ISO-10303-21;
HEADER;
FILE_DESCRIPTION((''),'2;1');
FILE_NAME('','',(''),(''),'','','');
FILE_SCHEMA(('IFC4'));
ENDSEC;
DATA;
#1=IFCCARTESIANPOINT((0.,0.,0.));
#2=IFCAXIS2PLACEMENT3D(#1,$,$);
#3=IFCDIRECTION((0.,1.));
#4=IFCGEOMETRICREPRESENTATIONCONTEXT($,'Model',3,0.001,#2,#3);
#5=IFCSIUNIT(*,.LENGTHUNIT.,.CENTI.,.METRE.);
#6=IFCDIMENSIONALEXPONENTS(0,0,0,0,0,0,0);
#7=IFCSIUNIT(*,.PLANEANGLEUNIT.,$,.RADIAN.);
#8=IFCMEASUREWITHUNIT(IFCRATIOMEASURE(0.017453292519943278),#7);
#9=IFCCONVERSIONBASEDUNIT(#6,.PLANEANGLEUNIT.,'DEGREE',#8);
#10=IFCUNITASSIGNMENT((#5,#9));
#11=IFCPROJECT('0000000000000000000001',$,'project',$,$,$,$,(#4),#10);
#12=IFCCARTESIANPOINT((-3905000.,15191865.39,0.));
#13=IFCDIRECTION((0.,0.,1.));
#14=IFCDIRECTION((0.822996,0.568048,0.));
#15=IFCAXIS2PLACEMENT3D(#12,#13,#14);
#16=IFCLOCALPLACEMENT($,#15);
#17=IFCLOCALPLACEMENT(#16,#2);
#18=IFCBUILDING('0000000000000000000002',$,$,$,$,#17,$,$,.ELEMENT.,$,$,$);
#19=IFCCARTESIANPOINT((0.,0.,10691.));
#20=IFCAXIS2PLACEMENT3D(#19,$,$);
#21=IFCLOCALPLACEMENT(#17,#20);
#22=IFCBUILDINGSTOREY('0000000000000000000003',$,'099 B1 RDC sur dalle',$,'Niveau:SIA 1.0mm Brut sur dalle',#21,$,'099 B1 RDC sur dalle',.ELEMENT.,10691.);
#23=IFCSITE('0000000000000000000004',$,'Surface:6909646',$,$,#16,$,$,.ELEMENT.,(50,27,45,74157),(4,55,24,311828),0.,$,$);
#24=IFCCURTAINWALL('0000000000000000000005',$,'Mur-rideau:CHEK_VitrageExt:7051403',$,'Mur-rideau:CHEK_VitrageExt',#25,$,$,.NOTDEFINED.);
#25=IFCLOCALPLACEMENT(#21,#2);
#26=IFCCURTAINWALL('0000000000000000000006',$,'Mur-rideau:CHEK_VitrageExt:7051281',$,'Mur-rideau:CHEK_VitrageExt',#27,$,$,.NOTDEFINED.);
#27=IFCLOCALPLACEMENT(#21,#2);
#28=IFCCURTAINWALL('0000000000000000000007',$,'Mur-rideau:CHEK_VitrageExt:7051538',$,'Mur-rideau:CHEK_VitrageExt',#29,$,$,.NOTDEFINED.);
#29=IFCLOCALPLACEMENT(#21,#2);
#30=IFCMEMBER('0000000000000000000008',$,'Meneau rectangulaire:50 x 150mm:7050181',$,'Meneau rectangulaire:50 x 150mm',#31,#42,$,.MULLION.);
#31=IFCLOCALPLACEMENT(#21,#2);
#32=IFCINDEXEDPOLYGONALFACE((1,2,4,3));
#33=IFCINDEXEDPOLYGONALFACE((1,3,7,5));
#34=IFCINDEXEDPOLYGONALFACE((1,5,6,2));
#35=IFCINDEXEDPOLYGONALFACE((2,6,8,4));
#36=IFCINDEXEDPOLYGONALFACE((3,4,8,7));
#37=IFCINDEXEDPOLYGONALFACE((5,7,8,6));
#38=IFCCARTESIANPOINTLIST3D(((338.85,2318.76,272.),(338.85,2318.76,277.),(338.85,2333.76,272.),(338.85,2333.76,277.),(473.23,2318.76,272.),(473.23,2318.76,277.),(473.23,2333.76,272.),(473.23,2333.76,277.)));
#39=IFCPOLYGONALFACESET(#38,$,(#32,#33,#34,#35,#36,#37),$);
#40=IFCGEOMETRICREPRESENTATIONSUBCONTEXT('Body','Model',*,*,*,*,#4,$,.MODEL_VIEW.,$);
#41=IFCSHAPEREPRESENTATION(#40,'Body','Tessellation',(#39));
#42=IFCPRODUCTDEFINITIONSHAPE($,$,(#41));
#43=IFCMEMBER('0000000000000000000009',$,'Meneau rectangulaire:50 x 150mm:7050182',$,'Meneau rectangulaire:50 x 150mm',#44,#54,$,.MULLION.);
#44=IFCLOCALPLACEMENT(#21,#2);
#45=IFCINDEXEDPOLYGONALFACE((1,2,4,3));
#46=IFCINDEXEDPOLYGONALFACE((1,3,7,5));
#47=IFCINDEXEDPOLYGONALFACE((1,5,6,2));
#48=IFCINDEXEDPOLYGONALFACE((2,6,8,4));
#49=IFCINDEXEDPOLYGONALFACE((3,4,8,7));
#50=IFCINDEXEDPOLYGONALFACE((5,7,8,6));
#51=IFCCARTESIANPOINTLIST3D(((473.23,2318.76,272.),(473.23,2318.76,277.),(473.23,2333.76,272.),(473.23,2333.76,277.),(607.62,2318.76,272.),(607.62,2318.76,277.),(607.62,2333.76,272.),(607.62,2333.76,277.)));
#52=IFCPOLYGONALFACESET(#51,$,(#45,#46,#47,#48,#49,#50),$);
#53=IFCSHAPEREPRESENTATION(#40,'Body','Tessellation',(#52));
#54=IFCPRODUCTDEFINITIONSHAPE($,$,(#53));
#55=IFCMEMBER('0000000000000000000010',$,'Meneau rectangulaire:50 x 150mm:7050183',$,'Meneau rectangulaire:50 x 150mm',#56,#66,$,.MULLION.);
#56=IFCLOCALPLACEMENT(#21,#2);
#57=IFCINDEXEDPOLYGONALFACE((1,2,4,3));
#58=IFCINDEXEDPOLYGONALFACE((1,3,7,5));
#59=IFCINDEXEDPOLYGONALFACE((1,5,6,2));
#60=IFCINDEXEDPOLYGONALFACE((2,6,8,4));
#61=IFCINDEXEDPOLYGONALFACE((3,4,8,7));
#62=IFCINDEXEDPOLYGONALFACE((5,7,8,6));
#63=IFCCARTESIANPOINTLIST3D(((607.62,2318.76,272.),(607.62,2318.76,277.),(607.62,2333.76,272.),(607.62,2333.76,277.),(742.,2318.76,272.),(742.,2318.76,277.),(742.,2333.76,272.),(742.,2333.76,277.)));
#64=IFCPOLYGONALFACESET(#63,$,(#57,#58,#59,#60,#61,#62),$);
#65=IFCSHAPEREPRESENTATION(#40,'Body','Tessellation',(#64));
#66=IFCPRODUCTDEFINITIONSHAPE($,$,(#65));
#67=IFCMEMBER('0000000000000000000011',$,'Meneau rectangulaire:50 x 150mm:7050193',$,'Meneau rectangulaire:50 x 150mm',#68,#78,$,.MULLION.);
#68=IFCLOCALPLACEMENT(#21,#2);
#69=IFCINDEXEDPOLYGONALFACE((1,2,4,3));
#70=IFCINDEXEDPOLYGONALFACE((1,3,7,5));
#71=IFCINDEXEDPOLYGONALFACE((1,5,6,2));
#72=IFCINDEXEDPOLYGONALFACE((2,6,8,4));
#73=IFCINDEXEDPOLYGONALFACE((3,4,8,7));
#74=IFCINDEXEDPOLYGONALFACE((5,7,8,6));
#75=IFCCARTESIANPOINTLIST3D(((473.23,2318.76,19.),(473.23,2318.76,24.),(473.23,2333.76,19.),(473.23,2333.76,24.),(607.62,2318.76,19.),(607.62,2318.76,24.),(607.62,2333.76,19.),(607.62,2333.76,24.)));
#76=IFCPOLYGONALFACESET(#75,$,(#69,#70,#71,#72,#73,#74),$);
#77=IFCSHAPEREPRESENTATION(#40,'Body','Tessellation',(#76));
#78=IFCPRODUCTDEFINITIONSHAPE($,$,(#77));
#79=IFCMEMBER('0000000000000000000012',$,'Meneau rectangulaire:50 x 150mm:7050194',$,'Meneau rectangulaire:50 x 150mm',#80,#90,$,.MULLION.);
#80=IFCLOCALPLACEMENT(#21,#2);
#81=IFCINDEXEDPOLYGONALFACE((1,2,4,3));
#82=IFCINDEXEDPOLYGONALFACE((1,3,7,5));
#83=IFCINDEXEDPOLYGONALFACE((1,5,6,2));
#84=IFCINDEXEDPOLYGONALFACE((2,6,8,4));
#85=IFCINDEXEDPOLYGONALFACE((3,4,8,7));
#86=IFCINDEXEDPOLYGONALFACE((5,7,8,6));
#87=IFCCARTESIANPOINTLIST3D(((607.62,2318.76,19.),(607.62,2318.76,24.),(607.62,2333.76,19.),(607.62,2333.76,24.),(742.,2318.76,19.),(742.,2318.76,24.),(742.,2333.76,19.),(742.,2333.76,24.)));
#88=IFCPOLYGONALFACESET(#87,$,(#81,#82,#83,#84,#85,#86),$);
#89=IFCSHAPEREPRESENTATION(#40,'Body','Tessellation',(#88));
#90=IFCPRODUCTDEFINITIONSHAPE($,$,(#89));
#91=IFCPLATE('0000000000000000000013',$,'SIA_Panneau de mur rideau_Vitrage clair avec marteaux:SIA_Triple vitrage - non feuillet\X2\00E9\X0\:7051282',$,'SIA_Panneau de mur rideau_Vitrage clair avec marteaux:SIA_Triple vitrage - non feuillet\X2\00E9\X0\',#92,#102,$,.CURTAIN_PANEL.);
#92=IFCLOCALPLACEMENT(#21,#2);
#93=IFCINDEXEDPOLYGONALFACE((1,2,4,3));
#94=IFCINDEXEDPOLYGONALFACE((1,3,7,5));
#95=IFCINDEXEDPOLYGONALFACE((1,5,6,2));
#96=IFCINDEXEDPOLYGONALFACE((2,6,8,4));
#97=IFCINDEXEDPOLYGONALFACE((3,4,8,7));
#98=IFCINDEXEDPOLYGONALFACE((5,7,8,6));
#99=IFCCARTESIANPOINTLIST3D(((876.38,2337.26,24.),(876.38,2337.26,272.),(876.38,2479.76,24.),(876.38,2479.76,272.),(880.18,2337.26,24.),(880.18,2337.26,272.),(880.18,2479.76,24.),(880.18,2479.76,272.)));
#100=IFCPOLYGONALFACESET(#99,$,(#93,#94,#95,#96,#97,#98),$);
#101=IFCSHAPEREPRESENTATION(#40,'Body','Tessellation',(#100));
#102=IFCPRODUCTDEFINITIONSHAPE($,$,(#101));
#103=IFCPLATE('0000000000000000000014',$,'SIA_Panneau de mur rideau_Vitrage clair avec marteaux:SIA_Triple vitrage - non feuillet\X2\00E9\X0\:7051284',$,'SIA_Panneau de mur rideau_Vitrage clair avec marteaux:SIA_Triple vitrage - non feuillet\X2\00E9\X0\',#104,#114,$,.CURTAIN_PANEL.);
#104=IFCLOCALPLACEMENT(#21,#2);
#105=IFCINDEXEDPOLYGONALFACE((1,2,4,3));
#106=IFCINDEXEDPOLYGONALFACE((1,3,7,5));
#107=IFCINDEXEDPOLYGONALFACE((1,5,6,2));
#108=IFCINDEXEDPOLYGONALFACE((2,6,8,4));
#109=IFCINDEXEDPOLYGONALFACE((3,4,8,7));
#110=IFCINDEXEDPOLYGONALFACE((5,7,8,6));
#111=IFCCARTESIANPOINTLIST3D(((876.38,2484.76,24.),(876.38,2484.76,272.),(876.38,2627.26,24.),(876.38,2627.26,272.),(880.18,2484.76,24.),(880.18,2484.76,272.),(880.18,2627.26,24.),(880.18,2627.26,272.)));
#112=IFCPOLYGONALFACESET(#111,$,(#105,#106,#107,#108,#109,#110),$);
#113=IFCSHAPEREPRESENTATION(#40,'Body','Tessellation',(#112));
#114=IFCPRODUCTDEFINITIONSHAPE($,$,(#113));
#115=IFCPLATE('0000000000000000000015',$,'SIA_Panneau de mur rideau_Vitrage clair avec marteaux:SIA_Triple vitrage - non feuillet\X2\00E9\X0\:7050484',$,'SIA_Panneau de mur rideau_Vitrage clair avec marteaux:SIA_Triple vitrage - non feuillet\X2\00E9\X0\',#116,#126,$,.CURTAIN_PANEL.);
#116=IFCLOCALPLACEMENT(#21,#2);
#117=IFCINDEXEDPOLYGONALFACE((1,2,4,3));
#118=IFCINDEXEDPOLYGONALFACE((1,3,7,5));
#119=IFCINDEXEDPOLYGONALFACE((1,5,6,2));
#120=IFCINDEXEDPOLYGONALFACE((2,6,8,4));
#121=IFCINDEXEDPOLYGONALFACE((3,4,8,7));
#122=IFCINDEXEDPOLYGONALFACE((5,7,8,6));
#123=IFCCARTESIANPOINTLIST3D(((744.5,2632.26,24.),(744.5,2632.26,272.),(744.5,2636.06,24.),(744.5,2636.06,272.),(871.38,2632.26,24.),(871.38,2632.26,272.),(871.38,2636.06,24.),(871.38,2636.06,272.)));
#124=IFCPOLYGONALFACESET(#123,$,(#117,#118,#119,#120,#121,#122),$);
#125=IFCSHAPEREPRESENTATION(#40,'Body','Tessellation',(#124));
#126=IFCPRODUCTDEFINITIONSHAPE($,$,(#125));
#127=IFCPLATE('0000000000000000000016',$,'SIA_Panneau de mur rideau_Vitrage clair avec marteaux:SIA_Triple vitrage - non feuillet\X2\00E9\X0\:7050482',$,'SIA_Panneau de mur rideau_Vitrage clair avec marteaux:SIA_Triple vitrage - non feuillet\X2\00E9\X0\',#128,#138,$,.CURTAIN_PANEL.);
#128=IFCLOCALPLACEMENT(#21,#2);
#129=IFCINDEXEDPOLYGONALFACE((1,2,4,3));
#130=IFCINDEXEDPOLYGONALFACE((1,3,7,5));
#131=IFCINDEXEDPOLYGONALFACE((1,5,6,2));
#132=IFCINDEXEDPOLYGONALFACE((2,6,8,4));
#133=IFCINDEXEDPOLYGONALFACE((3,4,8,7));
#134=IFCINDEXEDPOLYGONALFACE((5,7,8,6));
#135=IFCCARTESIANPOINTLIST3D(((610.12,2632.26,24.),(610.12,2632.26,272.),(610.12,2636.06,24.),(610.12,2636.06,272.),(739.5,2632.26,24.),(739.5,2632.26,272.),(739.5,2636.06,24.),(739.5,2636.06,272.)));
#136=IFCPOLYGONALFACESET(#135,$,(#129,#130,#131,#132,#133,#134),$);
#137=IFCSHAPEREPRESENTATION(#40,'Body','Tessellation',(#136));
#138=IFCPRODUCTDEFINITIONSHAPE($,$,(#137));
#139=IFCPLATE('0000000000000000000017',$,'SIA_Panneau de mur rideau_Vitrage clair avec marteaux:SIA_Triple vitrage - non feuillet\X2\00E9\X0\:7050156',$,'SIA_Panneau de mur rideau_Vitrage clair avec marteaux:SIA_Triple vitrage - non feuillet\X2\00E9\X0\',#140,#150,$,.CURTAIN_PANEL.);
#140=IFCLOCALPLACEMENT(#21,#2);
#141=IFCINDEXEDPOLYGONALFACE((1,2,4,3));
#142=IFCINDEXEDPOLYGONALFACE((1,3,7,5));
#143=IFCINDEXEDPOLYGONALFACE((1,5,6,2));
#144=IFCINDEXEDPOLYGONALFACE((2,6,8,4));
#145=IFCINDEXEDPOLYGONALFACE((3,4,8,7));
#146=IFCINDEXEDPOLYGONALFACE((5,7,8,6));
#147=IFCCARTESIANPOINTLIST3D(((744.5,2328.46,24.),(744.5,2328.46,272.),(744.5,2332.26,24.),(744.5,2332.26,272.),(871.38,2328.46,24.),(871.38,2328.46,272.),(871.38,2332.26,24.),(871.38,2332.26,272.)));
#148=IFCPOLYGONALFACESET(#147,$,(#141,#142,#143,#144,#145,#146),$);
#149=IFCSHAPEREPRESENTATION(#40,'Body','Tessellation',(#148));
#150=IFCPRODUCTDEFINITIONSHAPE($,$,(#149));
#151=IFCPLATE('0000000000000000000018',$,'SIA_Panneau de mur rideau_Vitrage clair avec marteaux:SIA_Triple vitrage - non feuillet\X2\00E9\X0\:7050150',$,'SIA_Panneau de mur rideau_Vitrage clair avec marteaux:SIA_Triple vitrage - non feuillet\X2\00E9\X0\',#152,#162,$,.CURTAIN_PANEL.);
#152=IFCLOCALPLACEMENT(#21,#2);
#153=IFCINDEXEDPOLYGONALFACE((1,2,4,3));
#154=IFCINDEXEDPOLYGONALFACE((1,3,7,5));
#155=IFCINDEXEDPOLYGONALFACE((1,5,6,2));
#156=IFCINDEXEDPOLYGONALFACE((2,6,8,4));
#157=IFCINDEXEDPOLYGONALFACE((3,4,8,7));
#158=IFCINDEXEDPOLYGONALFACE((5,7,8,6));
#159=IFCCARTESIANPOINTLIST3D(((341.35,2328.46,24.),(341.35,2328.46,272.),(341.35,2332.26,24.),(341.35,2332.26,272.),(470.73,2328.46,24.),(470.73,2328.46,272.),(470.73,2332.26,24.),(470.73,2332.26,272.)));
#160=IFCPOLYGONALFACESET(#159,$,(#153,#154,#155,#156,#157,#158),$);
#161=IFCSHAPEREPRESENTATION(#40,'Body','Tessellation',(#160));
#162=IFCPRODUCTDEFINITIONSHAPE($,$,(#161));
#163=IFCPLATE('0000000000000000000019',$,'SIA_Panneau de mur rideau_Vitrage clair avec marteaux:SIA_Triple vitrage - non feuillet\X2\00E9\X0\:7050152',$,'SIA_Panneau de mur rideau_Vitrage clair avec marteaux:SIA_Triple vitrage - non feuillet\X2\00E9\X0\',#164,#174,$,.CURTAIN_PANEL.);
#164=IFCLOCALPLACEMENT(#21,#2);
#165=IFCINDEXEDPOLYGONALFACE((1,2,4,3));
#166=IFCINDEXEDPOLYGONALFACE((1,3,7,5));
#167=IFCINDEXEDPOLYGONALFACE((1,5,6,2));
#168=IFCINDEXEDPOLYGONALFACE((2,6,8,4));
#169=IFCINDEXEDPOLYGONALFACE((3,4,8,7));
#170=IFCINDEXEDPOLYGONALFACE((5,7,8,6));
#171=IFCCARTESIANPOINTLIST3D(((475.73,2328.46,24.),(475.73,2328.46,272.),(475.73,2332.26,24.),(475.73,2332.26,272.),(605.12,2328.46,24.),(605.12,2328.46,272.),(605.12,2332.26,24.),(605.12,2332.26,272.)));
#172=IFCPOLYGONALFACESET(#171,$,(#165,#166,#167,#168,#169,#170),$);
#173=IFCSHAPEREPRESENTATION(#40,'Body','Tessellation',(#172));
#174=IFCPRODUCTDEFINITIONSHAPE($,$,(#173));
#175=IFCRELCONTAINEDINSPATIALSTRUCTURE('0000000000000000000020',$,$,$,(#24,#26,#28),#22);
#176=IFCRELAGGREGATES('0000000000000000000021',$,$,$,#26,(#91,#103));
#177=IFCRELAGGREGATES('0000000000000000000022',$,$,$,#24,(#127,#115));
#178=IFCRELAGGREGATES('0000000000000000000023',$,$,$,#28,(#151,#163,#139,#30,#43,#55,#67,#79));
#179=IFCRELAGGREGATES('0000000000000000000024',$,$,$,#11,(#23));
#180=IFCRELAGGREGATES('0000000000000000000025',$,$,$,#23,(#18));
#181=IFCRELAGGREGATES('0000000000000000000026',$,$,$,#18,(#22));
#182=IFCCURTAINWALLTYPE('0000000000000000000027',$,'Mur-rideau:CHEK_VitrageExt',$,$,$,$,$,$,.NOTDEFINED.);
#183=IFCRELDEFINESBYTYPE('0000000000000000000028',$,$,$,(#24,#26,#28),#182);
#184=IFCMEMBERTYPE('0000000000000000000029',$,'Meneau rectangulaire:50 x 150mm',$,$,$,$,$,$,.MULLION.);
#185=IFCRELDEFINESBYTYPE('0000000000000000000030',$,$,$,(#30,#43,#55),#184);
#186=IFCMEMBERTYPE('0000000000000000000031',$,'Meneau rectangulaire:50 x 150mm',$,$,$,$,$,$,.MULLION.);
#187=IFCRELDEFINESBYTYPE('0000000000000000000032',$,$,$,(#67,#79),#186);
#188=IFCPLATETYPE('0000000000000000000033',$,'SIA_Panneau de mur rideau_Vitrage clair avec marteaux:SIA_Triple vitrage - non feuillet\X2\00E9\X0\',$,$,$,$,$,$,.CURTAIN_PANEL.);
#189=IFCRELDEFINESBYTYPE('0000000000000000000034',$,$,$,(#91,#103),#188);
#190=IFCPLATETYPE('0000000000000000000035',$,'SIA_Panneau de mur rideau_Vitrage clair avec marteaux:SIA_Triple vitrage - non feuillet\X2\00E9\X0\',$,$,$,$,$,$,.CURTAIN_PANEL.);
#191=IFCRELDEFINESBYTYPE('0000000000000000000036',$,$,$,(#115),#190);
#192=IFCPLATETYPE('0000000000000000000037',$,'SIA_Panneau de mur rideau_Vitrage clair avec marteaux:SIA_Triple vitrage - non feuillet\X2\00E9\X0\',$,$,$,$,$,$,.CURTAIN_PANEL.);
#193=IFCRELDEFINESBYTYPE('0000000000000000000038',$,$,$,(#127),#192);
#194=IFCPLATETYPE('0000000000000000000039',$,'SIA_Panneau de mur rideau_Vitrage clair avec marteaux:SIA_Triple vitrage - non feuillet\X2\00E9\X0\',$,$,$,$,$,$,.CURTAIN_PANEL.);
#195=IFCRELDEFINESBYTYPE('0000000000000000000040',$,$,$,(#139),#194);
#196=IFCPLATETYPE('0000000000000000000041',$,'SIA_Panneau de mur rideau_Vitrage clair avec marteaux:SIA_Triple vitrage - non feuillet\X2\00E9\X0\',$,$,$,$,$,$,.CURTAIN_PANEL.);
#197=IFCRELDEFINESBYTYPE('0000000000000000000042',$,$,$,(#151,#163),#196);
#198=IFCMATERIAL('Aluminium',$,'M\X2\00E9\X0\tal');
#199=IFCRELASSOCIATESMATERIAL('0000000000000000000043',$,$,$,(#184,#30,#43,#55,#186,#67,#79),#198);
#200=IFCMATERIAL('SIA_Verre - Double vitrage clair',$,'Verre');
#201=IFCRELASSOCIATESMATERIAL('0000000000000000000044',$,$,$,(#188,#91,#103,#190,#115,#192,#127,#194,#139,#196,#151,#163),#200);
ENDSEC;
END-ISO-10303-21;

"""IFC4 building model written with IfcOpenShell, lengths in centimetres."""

from ifc_helpers import new_model, entity, si_unit, converted_unit, direction, frame, origin, place, context, subcontext, project, spatial, indexed_curve, outline, extrude, source, transform, mapped, material, type_object, type_shapes, element, aggregate, save


model = new_model("IFC4")

# Units and contexts
model_context = context("Model", 3, precision=0.001, world=origin(), true_north=direction((0.0, 1.0)))
body_context = subcontext(model_context, "Body", "Model", "MODEL_VIEW")
ifc_project = project(units=[si_unit("LENGTHUNIT", "METRE", prefix="CENTI"), converted_unit("PLANEANGLEUNIT", "DEGREE", entity("IfcRatioMeasure", 0.017453292519943278), si_unit("PLANEANGLEUNIT", "RADIAN"), dimensions=[0, 0, 0, 0, 0, 0, 0])], contexts=[model_context])

# Site, building, storey
site_placement = place(None, frame((-3905000.0, 15191865.39, 0.0), z_axis=(0.0, 0.0, 1.0), x_axis=(0.822996, 0.568048, 0.0)))
site = spatial("IfcSite", under=ifc_project, at=site_placement, Name="Surface:6909646", CompositionType="ELEMENT", RefLatitude=(50, 27, 45, 74157), RefLongitude=(4, 55, 24, 311828), RefElevation=0.0)
building_placement = place(site_placement, origin())
building = spatial("IfcBuilding", under=site, at=building_placement, CompositionType="ELEMENT")
storey_placement = place(building_placement, frame((0.0, 0.0, 10691.0)))
storey = spatial("IfcBuildingStorey", under=building, at=storey_placement, Name="099 B1 RDC sur dalle", ObjectType="Niveau:SIA 1.0mm Brut sur dalle", LongName="099 B1 RDC sur dalle", CompositionType="ELEMENT", Elevation=10691.0)

# Curtain wall
curtain_wall_type = type_object("IfcCurtainWallType", Name="Mur-rideau:CHEK_VitrageExt", PredefinedType="NOTDEFINED")
curtain_wall_1_placement = place(storey_placement, frame((0.0, 0.0, -10691.0)))
curtain_wall_1 = element("IfcCurtainWall", 1, at=curtain_wall_1_placement, inside=storey, type_object=curtain_wall_type, Name="Mur-rideau:CHEK_VitrageExt:7051403", ObjectType="Mur-rideau:CHEK_VitrageExt", PredefinedType="NOTDEFINED")
ifc_material_1 = material(Name="Aluminium", Category="Métal")

# Curtain wall
curtain_wall_2_placement = place(storey_placement, frame((0.0, 0.0, -10691.0)))
curtain_wall_2 = element("IfcCurtainWall", 2, at=curtain_wall_2_placement, inside=storey, type_object=curtain_wall_type, Name="Mur-rideau:CHEK_VitrageExt:7051281", ObjectType="Mur-rideau:CHEK_VitrageExt", PredefinedType="NOTDEFINED")

# Curtain wall
curtain_wall_3_placement = place(storey_placement, frame((0.0, 0.0, -10691.0)))
curtain_wall_3 = element("IfcCurtainWall", 3, at=curtain_wall_3_placement, inside=storey, type_object=curtain_wall_type, Name="Mur-rideau:CHEK_VitrageExt:7051538", ObjectType="Mur-rideau:CHEK_VitrageExt", PredefinedType="NOTDEFINED")

# Members
member_type_1 = type_object("IfcMemberType", Name="Meneau rectangulaire:50 x 150mm", PredefinedType="MULLION", material=ifc_material_1)
shared_shape_1 = source(origin(), body_context, "Body", "SweptSolid", [
    extrude(outline(indexed_curve([(-7.5, -2.5), (7.5, -2.5), (7.5, 2.5), (-7.5, 2.5), (-7.5, -2.5)], self_intersect=False)), frame((-2.5, 6.0, -134.38), z_axis=(0.0, 0.0, 1.0), x_axis=(0.0, -1.0, 0.0)), (0.0, 0.0, 1.0), 134.38),
])
type_shapes(member_type_1, [shared_shape_1])
member_1_placement = place(curtain_wall_3_placement, frame((473.23, 2332.26, 10968.0), z_axis=(1.0, 0.0, 0.0), x_axis=(0.0, 0.0, 1.0)))
member_1 = element("IfcMember", 4, at=member_1_placement, type_object=member_type_1, material=ifc_material_1, Name="Meneau rectangulaire:50 x 150mm:7050181", ObjectType="Meneau rectangulaire:50 x 150mm", PredefinedType="MULLION", context=body_context, shape_type="MappedRepresentation", body=[
    mapped(shared_shape_1, transform((0.0, 0.0, 0.0), scale=1.0)),
])
member_2_placement = place(curtain_wall_3_placement, frame((607.62, 2332.26, 10968.0), z_axis=(1.0, 0.0, 0.0), x_axis=(0.0, 0.0, 1.0)))
member_2 = element("IfcMember", 5, at=member_2_placement, type_object=member_type_1, material=ifc_material_1, Name="Meneau rectangulaire:50 x 150mm:7050182", ObjectType="Meneau rectangulaire:50 x 150mm", PredefinedType="MULLION", context=body_context, shape_type="MappedRepresentation", body=[
    mapped(shared_shape_1, transform((0.0, 0.0, 0.0), scale=1.0)),
])
member_3_placement = place(curtain_wall_3_placement, frame((742.0, 2332.26, 10968.0), z_axis=(1.0, 0.0, 0.0), x_axis=(0.0, 0.0, 1.0)))
member_3 = element("IfcMember", 6, at=member_3_placement, type_object=member_type_1, material=ifc_material_1, Name="Meneau rectangulaire:50 x 150mm:7050183", ObjectType="Meneau rectangulaire:50 x 150mm", PredefinedType="MULLION", context=body_context, shape_type="MappedRepresentation", body=[
    mapped(shared_shape_1, transform((0.0, 0.0, 0.0), scale=1.0)),
])
member_type_2 = type_object("IfcMemberType", Name="Meneau rectangulaire:50 x 150mm", PredefinedType="MULLION", material=ifc_material_1)
shared_shape_2 = source(origin(), body_context, "Body", "SweptSolid", [
    extrude(outline(indexed_curve([(-7.5, -2.5), (7.5, -2.5), (7.5, 2.5), (-7.5, 2.5), (-7.5, -2.5)], self_intersect=False)), frame((-2.5, 6.0, -134.38), z_axis=(0.0, 0.0, 1.0), x_axis=(0.0, -1.0, 0.0)), (0.0, 0.0, 1.0), 134.38),
])
type_shapes(member_type_2, [shared_shape_2])
member_4_placement = place(curtain_wall_3_placement, frame((473.23, 2332.26, 10710.0), z_axis=(-1.0, 0.0, 0.0), x_axis=(0.0, 0.0, -1.0)))
member_4 = element("IfcMember", 7, at=member_4_placement, type_object=member_type_2, material=ifc_material_1, Name="Meneau rectangulaire:50 x 150mm:7050193", ObjectType="Meneau rectangulaire:50 x 150mm", PredefinedType="MULLION", context=body_context, shape_type="MappedRepresentation", body=[
    mapped(shared_shape_2, transform((0.0, 0.0, 0.0), scale=1.0)),
])
member_5_placement = place(curtain_wall_3_placement, frame((607.62, 2332.26, 10710.0), z_axis=(-1.0, 0.0, 0.0), x_axis=(0.0, 0.0, -1.0)))
member_5 = element("IfcMember", 8, at=member_5_placement, type_object=member_type_2, material=ifc_material_1, Name="Meneau rectangulaire:50 x 150mm:7050194", ObjectType="Meneau rectangulaire:50 x 150mm", PredefinedType="MULLION", context=body_context, shape_type="MappedRepresentation", body=[
    mapped(shared_shape_2, transform((0.0, 0.0, 0.0), scale=1.0)),
])

# Plates
ifc_material_2 = material(Name="SIA_Verre - Double vitrage clair", Category="Verre")
plate_type_1 = type_object("IfcPlateType", Name="SIA_Panneau de mur rideau_Vitrage clair avec marteaux:SIA_Triple vitrage - non feuilleté", PredefinedType="CURTAIN_PANEL", material=ifc_material_2)
shared_shape_3 = source(origin(), body_context, "Body", "SweptSolid", [
    extrude(outline(indexed_curve([(-1.9, -71.25), (1.9, -71.25), (1.9, 71.25), (-1.9, 71.25), (-1.9, -71.25)], self_intersect=False)), frame((0.0, -1.9, 0.0), z_axis=(0.0, 0.0, 1.0), x_axis=(0.0, 1.0, 0.0)), (0.0, 0.0, 1.0), 248.0),
])
type_shapes(plate_type_1, [shared_shape_3])
plate_1_placement = place(curtain_wall_2_placement, frame((876.38, 2408.51, 10715.0), z_axis=(0.0, 0.0, 1.0), x_axis=(0.0, 1.0, 0.0)))
plate_1 = element("IfcPlate", 9, at=plate_1_placement, type_object=plate_type_1, material=ifc_material_2, Name="SIA_Panneau de mur rideau_Vitrage clair avec marteaux:SIA_Triple vitrage - non feuilleté:7051282", ObjectType="SIA_Panneau de mur rideau_Vitrage clair avec marteaux:SIA_Triple vitrage - non feuilleté", PredefinedType="CURTAIN_PANEL", context=body_context, shape_type="MappedRepresentation", body=[
    mapped(shared_shape_3, transform((0.0, 0.0, 0.0), scale=1.0)),
])
plate_2_placement = place(curtain_wall_2_placement, frame((876.38, 2556.01, 10715.0), z_axis=(0.0, 0.0, 1.0), x_axis=(0.0, 1.0, 0.0)))
plate_2 = element("IfcPlate", 10, at=plate_2_placement, type_object=plate_type_1, material=ifc_material_2, Name="SIA_Panneau de mur rideau_Vitrage clair avec marteaux:SIA_Triple vitrage - non feuilleté:7051284", ObjectType="SIA_Panneau de mur rideau_Vitrage clair avec marteaux:SIA_Triple vitrage - non feuilleté", PredefinedType="CURTAIN_PANEL", context=body_context, shape_type="MappedRepresentation", body=[
    mapped(shared_shape_3, transform((0.0, 0.0, 0.0), scale=1.0)),
])
aggregate(curtain_wall_2, [plate_1, plate_2])
plate_type_2 = type_object("IfcPlateType", Name="SIA_Panneau de mur rideau_Vitrage clair avec marteaux:SIA_Triple vitrage - non feuilleté", PredefinedType="CURTAIN_PANEL", material=ifc_material_2)
shared_shape_4 = source(origin(), body_context, "Body", "SweptSolid", [
    extrude(outline(indexed_curve([(-63.44, -1.9), (63.44, -1.9), (63.44, 1.9), (-63.44, 1.9), (-63.44, -1.9)], self_intersect=False)), frame((0.0, 1.9, 0.0), z_axis=(0.0, 0.0, 1.0), x_axis=(-1.0, 0.0, 0.0)), (0.0, 0.0, 1.0), 248.0),
])
type_shapes(plate_type_2, [shared_shape_4])
plate_3_placement = place(curtain_wall_1_placement, frame((807.94, 2632.26, 10715.0)))
plate_3 = element("IfcPlate", 11, at=plate_3_placement, type_object=plate_type_2, material=ifc_material_2, Name="SIA_Panneau de mur rideau_Vitrage clair avec marteaux:SIA_Triple vitrage - non feuilleté:7050484", ObjectType="SIA_Panneau de mur rideau_Vitrage clair avec marteaux:SIA_Triple vitrage - non feuilleté", PredefinedType="CURTAIN_PANEL", context=body_context, shape_type="MappedRepresentation", body=[
    mapped(shared_shape_4, transform((0.0, 0.0, 0.0), scale=1.0)),
])
plate_type_3 = type_object("IfcPlateType", Name="SIA_Panneau de mur rideau_Vitrage clair avec marteaux:SIA_Triple vitrage - non feuilleté", PredefinedType="CURTAIN_PANEL", material=ifc_material_2)
shared_shape_5 = source(origin(), body_context, "Body", "SweptSolid", [
    extrude(outline(indexed_curve([(-64.69, -1.9), (64.69, -1.9), (64.69, 1.9), (-64.69, 1.9), (-64.69, -1.9)], self_intersect=False)), frame((0.0, 1.9, 0.0), z_axis=(0.0, 0.0, 1.0), x_axis=(-1.0, 0.0, 0.0)), (0.0, 0.0, 1.0), 248.0),
])
type_shapes(plate_type_3, [shared_shape_5])
plate_4_placement = place(curtain_wall_1_placement, frame((674.81, 2632.26, 10715.0)))
plate_4 = element("IfcPlate", 12, at=plate_4_placement, type_object=plate_type_3, material=ifc_material_2, Name="SIA_Panneau de mur rideau_Vitrage clair avec marteaux:SIA_Triple vitrage - non feuilleté:7050482", ObjectType="SIA_Panneau de mur rideau_Vitrage clair avec marteaux:SIA_Triple vitrage - non feuilleté", PredefinedType="CURTAIN_PANEL", context=body_context, shape_type="MappedRepresentation", body=[
    mapped(shared_shape_5, transform((0.0, 0.0, 0.0), scale=1.0)),
])
aggregate(curtain_wall_1, [plate_4, plate_3])
plate_type_4 = type_object("IfcPlateType", Name="SIA_Panneau de mur rideau_Vitrage clair avec marteaux:SIA_Triple vitrage - non feuilleté", PredefinedType="CURTAIN_PANEL", material=ifc_material_2)
shared_shape_6 = source(origin(), body_context, "Body", "SweptSolid", [
    extrude(outline(indexed_curve([(-1.9, -63.44), (1.9, -63.44), (1.9, 63.44), (-1.9, 63.44), (-1.9, -63.44)], self_intersect=False)), frame((0.0, -1.9, 0.0), z_axis=(0.0, 0.0, 1.0), x_axis=(0.0, 1.0, 0.0)), (0.0, 0.0, 1.0), 248.0),
])
type_shapes(plate_type_4, [shared_shape_6])
plate_5_placement = place(curtain_wall_3_placement, frame((807.94, 2332.26, 10715.0)))
plate_5 = element("IfcPlate", 13, at=plate_5_placement, type_object=plate_type_4, material=ifc_material_2, Name="SIA_Panneau de mur rideau_Vitrage clair avec marteaux:SIA_Triple vitrage - non feuilleté:7050156", ObjectType="SIA_Panneau de mur rideau_Vitrage clair avec marteaux:SIA_Triple vitrage - non feuilleté", PredefinedType="CURTAIN_PANEL", context=body_context, shape_type="MappedRepresentation", body=[
    mapped(shared_shape_6, transform((0.0, 0.0, 0.0), scale=1.0)),
])
plate_type_5 = type_object("IfcPlateType", Name="SIA_Panneau de mur rideau_Vitrage clair avec marteaux:SIA_Triple vitrage - non feuilleté", PredefinedType="CURTAIN_PANEL", material=ifc_material_2)
shared_shape_7 = source(origin(), body_context, "Body", "SweptSolid", [
    extrude(outline(indexed_curve([(-1.9, -64.69), (1.9, -64.69), (1.9, 64.69), (-1.9, 64.69), (-1.9, -64.69)], self_intersect=False)), frame((0.0, -1.9, 0.0), z_axis=(0.0, 0.0, 1.0), x_axis=(0.0, 1.0, 0.0)), (0.0, 0.0, 1.0), 248.0),
])
type_shapes(plate_type_5, [shared_shape_7])
plate_6_placement = place(curtain_wall_3_placement, frame((406.04, 2332.26, 10715.0)))
plate_6 = element("IfcPlate", 14, at=plate_6_placement, type_object=plate_type_5, material=ifc_material_2, Name="SIA_Panneau de mur rideau_Vitrage clair avec marteaux:SIA_Triple vitrage - non feuilleté:7050150", ObjectType="SIA_Panneau de mur rideau_Vitrage clair avec marteaux:SIA_Triple vitrage - non feuilleté", PredefinedType="CURTAIN_PANEL", context=body_context, shape_type="MappedRepresentation", body=[
    mapped(shared_shape_7, transform((0.0, 0.0, 0.0), scale=1.0)),
])
plate_7_placement = place(curtain_wall_3_placement, frame((540.43, 2332.26, 10715.0)))
plate_7 = element("IfcPlate", 15, at=plate_7_placement, type_object=plate_type_5, material=ifc_material_2, Name="SIA_Panneau de mur rideau_Vitrage clair avec marteaux:SIA_Triple vitrage - non feuilleté:7050152", ObjectType="SIA_Panneau de mur rideau_Vitrage clair avec marteaux:SIA_Triple vitrage - non feuilleté", PredefinedType="CURTAIN_PANEL", context=body_context, shape_type="MappedRepresentation", body=[
    mapped(shared_shape_7, transform((0.0, 0.0, 0.0), scale=1.0)),
])
aggregate(curtain_wall_3, [plate_6, plate_7, plate_5, member_1, member_2, member_3, member_4, member_5])

save(model, "model.ifc")
